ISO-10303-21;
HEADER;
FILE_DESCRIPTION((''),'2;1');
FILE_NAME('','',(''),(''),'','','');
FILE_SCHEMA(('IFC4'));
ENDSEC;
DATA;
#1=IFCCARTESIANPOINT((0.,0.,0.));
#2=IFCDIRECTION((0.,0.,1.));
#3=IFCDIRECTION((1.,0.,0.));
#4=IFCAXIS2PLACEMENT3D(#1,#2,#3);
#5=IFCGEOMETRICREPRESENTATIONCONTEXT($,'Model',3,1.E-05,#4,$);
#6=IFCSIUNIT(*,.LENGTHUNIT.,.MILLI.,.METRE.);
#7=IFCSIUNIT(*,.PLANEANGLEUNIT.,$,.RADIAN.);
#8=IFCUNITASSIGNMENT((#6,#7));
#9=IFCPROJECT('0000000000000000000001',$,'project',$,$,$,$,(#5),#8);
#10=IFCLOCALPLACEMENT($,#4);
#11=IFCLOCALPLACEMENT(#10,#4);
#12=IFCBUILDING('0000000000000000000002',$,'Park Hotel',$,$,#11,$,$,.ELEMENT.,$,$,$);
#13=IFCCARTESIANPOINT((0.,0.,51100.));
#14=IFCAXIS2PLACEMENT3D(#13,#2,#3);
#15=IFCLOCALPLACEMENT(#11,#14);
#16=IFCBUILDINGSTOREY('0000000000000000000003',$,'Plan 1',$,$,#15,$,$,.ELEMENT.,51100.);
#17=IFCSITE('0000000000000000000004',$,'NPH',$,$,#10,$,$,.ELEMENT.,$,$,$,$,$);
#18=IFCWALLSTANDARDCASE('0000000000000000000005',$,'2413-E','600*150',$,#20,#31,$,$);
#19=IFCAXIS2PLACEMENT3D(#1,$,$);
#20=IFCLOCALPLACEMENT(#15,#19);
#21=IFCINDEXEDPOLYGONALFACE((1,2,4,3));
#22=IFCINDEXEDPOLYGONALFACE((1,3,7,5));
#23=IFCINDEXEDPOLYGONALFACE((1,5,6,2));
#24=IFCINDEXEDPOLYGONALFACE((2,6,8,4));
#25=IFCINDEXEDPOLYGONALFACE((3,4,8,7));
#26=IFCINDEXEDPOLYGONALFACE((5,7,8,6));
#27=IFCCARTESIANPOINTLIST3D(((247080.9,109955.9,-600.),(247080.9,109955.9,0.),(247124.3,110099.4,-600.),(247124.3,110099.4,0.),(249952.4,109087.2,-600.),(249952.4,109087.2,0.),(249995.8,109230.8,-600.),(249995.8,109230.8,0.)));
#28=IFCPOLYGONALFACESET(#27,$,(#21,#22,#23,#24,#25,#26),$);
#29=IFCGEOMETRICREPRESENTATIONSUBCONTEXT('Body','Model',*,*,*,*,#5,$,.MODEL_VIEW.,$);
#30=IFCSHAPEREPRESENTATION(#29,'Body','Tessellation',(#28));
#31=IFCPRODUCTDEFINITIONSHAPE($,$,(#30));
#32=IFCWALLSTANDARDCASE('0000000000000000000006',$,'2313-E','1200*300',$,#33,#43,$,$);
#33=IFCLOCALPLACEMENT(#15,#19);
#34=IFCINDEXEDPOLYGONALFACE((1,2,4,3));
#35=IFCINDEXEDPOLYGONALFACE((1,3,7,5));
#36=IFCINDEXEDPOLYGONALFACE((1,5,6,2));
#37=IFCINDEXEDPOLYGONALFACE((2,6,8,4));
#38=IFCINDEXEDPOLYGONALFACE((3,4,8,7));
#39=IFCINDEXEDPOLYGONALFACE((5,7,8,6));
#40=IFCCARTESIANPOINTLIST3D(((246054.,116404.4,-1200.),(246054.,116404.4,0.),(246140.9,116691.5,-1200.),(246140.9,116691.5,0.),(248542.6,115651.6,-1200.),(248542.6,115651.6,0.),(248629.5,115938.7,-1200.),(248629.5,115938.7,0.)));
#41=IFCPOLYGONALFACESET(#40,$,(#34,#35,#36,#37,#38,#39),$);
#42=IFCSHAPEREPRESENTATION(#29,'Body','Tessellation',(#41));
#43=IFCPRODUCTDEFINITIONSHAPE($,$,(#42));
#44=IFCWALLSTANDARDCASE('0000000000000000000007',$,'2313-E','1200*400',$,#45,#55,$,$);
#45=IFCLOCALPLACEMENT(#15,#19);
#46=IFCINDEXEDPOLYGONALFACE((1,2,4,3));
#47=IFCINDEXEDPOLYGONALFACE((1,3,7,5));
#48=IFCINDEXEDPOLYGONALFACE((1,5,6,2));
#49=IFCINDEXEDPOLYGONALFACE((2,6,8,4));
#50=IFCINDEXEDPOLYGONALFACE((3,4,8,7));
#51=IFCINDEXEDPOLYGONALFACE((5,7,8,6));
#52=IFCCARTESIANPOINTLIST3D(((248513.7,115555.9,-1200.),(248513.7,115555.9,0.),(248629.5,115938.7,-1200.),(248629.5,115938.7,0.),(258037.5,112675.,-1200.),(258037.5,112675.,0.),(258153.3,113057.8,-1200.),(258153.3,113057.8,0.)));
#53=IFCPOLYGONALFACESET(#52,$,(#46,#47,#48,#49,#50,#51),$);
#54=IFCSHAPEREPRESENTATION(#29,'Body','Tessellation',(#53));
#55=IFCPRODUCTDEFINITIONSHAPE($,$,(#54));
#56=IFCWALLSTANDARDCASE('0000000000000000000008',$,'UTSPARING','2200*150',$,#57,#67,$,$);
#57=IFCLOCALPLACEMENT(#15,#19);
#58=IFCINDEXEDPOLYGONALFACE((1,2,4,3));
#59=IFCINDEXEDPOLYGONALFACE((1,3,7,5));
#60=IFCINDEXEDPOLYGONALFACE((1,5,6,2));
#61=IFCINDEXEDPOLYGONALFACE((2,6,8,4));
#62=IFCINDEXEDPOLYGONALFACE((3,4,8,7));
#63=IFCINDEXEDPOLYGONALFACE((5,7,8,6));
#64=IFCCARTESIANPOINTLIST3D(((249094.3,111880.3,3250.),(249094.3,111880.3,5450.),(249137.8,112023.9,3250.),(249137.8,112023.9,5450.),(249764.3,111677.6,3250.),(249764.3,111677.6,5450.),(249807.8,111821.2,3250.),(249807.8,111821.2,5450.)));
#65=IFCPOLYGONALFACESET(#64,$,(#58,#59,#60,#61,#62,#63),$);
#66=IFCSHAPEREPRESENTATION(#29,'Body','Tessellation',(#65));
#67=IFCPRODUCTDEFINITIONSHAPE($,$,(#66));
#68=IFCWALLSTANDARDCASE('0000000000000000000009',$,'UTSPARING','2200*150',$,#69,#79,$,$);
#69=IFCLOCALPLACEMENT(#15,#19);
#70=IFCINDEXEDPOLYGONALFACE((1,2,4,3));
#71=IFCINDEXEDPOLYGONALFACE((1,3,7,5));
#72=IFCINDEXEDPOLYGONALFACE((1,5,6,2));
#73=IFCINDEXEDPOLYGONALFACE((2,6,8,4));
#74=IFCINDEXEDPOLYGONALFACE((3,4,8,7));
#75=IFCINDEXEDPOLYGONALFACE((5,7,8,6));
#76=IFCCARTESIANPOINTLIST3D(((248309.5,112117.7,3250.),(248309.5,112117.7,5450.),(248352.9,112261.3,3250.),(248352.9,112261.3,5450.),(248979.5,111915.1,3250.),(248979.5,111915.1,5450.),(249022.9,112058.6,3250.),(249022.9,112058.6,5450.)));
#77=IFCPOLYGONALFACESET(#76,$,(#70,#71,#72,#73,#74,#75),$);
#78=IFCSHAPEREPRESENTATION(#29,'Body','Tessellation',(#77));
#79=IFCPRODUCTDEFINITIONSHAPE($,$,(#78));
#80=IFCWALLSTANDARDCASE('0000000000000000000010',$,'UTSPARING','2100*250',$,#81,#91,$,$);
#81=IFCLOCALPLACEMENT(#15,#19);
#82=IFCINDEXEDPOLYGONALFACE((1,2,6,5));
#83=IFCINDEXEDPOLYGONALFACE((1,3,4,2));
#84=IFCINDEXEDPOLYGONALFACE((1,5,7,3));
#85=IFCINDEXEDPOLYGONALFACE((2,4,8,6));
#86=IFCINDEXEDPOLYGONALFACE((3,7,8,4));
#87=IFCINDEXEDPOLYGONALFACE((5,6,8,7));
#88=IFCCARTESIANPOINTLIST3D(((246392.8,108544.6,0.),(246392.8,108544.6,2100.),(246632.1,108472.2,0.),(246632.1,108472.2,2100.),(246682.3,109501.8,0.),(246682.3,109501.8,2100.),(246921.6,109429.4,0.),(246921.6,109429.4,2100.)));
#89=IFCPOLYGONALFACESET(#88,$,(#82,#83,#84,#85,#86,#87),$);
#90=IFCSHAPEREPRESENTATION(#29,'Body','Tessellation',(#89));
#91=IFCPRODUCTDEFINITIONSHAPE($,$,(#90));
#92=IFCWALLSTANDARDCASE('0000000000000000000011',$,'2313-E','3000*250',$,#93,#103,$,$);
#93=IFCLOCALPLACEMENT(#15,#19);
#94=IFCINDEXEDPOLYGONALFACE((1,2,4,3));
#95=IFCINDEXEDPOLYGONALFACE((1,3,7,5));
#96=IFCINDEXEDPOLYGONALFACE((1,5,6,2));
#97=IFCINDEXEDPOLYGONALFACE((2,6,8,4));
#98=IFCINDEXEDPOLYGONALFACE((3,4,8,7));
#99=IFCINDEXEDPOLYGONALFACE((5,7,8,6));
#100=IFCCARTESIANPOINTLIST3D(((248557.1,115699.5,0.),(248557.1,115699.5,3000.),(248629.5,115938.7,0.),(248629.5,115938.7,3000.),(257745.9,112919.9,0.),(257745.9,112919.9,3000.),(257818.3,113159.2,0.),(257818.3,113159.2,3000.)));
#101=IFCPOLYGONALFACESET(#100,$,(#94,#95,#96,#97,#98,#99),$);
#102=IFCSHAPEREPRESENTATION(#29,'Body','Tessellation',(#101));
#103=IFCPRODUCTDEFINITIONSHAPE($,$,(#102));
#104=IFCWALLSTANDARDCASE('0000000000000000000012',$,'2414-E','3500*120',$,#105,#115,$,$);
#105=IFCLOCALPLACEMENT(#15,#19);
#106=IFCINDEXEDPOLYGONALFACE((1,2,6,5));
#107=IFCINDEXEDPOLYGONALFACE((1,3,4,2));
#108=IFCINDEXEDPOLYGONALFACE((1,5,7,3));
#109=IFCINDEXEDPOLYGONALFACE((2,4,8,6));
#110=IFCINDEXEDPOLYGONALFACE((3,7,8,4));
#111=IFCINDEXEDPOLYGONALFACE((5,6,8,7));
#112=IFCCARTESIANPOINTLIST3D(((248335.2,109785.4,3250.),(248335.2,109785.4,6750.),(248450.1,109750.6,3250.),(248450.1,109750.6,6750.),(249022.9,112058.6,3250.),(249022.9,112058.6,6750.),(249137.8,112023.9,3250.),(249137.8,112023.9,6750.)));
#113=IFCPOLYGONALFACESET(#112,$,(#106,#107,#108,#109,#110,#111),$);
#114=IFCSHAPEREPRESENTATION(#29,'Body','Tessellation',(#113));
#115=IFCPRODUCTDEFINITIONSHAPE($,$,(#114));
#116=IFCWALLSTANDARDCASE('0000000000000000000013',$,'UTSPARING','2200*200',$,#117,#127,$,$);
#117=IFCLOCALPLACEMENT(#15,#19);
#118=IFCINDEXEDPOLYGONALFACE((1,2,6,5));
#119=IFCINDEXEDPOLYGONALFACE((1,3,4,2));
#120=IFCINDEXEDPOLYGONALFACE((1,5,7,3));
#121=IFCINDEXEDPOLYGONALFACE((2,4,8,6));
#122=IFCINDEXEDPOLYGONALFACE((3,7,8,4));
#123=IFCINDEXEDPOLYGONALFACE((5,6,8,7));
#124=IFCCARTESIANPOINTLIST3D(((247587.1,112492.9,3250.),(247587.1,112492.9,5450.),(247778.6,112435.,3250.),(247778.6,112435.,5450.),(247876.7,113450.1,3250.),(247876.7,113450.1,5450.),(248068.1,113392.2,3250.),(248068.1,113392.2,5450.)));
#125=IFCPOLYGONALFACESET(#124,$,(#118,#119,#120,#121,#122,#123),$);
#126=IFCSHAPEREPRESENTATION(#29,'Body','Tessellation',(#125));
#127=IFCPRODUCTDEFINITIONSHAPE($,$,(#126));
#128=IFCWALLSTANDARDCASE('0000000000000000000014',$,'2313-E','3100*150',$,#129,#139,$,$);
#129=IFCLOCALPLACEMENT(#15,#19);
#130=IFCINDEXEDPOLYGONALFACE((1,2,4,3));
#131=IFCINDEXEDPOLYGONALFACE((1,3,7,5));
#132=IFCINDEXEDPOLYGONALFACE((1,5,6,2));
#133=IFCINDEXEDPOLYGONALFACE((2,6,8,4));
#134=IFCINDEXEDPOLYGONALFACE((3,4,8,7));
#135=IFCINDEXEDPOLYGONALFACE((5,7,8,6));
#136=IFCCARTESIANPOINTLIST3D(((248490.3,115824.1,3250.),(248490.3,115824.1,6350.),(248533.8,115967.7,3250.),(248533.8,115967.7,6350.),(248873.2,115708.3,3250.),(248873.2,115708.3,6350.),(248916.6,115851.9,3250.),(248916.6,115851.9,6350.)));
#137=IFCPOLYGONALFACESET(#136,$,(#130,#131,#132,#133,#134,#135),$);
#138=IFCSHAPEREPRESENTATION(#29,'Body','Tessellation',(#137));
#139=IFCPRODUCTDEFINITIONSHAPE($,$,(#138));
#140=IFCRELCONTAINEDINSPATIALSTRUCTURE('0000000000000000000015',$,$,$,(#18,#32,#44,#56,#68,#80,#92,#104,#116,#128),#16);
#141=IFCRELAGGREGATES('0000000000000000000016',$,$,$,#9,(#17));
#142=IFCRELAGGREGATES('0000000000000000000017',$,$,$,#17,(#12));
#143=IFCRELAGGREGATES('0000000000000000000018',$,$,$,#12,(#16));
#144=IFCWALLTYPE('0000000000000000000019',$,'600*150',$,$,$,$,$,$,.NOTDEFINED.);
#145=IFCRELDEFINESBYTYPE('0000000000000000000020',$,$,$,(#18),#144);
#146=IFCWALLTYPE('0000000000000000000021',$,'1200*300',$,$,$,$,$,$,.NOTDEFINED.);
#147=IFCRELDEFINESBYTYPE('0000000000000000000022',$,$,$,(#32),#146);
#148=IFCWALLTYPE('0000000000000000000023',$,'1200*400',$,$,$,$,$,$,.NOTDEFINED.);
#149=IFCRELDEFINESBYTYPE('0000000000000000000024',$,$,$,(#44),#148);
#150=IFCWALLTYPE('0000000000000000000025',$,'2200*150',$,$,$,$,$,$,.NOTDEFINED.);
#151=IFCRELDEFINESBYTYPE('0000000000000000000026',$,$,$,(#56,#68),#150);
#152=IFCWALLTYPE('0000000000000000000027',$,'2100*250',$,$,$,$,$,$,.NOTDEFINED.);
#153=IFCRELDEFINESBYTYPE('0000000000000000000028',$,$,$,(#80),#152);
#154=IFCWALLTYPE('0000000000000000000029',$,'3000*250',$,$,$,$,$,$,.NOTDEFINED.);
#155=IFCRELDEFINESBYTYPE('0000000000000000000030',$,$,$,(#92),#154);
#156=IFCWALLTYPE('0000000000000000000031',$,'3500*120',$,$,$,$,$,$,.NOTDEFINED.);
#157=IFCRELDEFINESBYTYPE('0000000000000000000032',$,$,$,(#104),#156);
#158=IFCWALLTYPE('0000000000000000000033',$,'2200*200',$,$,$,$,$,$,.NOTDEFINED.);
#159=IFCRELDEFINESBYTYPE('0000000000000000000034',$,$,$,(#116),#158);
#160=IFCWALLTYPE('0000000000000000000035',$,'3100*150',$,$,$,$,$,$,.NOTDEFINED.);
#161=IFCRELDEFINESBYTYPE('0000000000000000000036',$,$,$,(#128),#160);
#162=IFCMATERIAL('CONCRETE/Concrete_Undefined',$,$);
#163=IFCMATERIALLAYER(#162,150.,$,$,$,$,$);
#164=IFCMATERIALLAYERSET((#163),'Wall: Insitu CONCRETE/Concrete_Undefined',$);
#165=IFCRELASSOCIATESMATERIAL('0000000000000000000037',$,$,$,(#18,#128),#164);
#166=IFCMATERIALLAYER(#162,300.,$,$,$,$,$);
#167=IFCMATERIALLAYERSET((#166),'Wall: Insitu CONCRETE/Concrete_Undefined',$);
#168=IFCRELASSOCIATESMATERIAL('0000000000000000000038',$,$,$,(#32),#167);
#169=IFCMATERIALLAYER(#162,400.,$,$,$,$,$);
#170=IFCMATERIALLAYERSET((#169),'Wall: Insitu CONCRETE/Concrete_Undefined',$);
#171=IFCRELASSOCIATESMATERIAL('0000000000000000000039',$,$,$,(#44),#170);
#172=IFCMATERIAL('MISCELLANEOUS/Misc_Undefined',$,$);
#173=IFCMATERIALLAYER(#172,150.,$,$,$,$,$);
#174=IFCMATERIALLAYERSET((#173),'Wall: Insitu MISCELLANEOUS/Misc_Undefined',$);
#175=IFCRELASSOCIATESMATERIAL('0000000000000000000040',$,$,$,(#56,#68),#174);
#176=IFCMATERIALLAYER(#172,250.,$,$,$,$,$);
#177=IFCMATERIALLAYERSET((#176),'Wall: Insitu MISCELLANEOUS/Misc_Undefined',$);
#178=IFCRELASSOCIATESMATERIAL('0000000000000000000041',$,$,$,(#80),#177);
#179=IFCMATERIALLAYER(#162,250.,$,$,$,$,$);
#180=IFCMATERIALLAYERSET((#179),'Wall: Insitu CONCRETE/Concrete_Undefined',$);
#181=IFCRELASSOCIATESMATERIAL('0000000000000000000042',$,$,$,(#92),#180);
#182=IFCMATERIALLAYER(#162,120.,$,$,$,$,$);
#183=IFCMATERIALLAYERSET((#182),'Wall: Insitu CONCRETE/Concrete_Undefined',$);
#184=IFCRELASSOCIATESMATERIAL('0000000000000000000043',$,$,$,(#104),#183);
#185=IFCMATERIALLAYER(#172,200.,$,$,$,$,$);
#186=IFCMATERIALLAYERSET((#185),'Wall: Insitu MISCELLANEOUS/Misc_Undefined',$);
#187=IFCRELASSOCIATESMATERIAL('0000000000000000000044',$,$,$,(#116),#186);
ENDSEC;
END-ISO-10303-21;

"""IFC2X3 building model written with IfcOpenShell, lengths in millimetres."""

from ifc_helpers import new_model, si_unit, frame, frame_2d, origin_with_axes, place, context, subcontext, project, spatial, rectangle, extrude, material, layer, layer_set, layer_usage, type_object, element, save


model = new_model("IFC2X3")

# Units and contexts
model_context = context("Model", 3, precision=1e-05, world=origin_with_axes())
body_context = subcontext(model_context, "Body", "Model", "MODEL_VIEW")
ifc_project = project(units=[si_unit("LENGTHUNIT", "METRE", prefix="MILLI"), si_unit("PLANEANGLEUNIT", "RADIAN")], contexts=[model_context])

# Site, building, storey
site_placement = place(None, origin_with_axes())
site = spatial("IfcSite", under=ifc_project, at=site_placement, Name="NPH", CompositionType="ELEMENT")
building_placement = place(site_placement, origin_with_axes())
building = spatial("IfcBuilding", under=site, at=building_placement, Name="Park Hotel", CompositionType="ELEMENT")
storey_placement = place(building_placement, frame((0.0, 0.0, 51100.0), z_axis=(0.0, 0.0, 1.0), x_axis=(1.0, 0.0, 0.0)))
storey = spatial("IfcBuildingStorey", under=building, at=storey_placement, Name="Plan 1", CompositionType="ELEMENT", Elevation=51100.0)

# Shared definitions
ifc_material_1 = material(Name="CONCRETE/Concrete_Undefined")

# Shared definitions
ifc_material_2 = material(Name="MISCELLANEOUS/Misc_Undefined")

# Walls
ifc_layer_1 = layer(ifc_material_1, 150.0)
ifc_layer_set_1 = layer_set([ifc_layer_1], Name="Wall: Insitu CONCRETE/Concrete_Undefined")
ifc_layer_usage_1 = layer_usage(ifc_layer_set_1, "AXIS2", "POSITIVE", -75.0)
wall_type_1 = type_object("IfcWallType", Name="600*150", PredefinedType="NOTDEFINED")
wall_1_placement = place(storey_placement, frame((247102.6, 110027.6, -600.0), z_axis=(0.0, 0.0, 1.0), x_axis=(0.957167, -0.289536, 0.0)))
element("IfcWallStandardCase", 1, at=wall_1_placement, inside=storey, type_object=wall_type_1, material=ifc_layer_usage_1, Name="2413-E", Description="600*150", context=body_context, shape_type="SweptSolid", body=[
    extrude(rectangle(XDim=3000.0, YDim=150.0, at=frame_2d((0.0, 1500.0), x_axis=(0.0, -1.0))), frame((0.0, 0.0, 0.0), z_axis=(0.0, 0.0, 1.0), x_axis=(0.0, -1.0, 0.0)), (0.0, 0.0, 1.0), 600.0),
])
ifc_layer_2 = layer(ifc_material_1, 300.0)
ifc_layer_set_2 = layer_set([ifc_layer_2], Name="Wall: Insitu CONCRETE/Concrete_Undefined")
ifc_layer_usage_2 = layer_usage(ifc_layer_set_2, "AXIS2", "POSITIVE", -150.0)
wall_type_2 = type_object("IfcWallType", Name="1200*300", PredefinedType="NOTDEFINED")
wall_2_placement = place(storey_placement, frame((246097.4, 116548.0, -1200.0), z_axis=(0.0, 0.0, 1.0), x_axis=(0.957166, -0.289541, 0.0)))
element("IfcWallStandardCase", 2, at=wall_2_placement, inside=storey, type_object=wall_type_2, material=ifc_layer_usage_2, Name="2313-E", Description="1200*300", context=body_context, shape_type="SweptSolid", body=[
    extrude(rectangle(XDim=2600.0, YDim=300.0, at=frame_2d((0.0, 1300.0), x_axis=(0.0, -1.0))), frame((0.0, 0.0, 0.0), z_axis=(0.0, 0.0, 1.0), x_axis=(0.0, -1.0, 0.0)), (0.0, 0.0, 1.0), 1200.0),
])
ifc_layer_3 = layer(ifc_material_1, 400.0)
ifc_layer_set_3 = layer_set([ifc_layer_3], Name="Wall: Insitu CONCRETE/Concrete_Undefined")
ifc_layer_usage_3 = layer_usage(ifc_layer_set_3, "AXIS2", "POSITIVE", -200.0)
wall_type_3 = type_object("IfcWallType", Name="1200*400", PredefinedType="NOTDEFINED")
wall_3_placement = place(storey_placement, frame((248571.6, 115747.3, -1200.0), z_axis=(0.0, 0.0, 1.0), x_axis=(0.957167, -0.289538, 0.0)))
element("IfcWallStandardCase", 3, at=wall_3_placement, inside=storey, type_object=wall_type_3, material=ifc_layer_usage_3, Name="2313-E", Description="1200*400", context=body_context, shape_type="SweptSolid", body=[
    extrude(rectangle(XDim=9950.0, YDim=400.0, at=frame_2d((0.0, 4975.0), x_axis=(0.0, -1.0))), frame((0.0, 0.0, 0.0), z_axis=(0.0, 0.0, 1.0), x_axis=(0.0, -1.0, 0.0)), (0.0, 0.0, 1.0), 1200.0),
])
ifc_layer_4 = layer(ifc_material_2, 150.0)
ifc_layer_set_4 = layer_set([ifc_layer_4], Name="Wall: Insitu MISCELLANEOUS/Misc_Undefined")
ifc_layer_usage_4 = layer_usage(ifc_layer_set_4, "AXIS2", "POSITIVE", -75.0)
wall_type_4 = type_object("IfcWallType", Name="2200*150", PredefinedType="NOTDEFINED")
wall_4_placement = place(storey_placement, frame((249786.1, 111749.4, 3250.0), z_axis=(0.0, 0.0, 1.0), x_axis=(-0.957165, 0.289542, 0.0)))
element("IfcWallStandardCase", 4, at=wall_4_placement, inside=storey, type_object=wall_type_4, material=ifc_layer_usage_4, Name="UTSPARING", Description="2200*150", context=body_context, shape_type="SweptSolid", body=[
    extrude(rectangle(XDim=700.0, YDim=150.0, at=frame_2d((0.0, 350.0), x_axis=(0.0, -1.0))), frame((0.0, 0.0, 0.0), z_axis=(0.0, 0.0, 1.0), x_axis=(0.0, -1.0, 0.0)), (0.0, 0.0, 1.0), 2200.0),
])
ifc_layer_usage_5 = layer_usage(ifc_layer_set_4, "AXIS2", "POSITIVE", -75.0)
wall_5_placement = place(storey_placement, frame((249001.2, 111986.8, 3250.0), z_axis=(0.0, 0.0, 1.0), x_axis=(-0.957165, 0.289542, 0.0)))
element("IfcWallStandardCase", 5, at=wall_5_placement, inside=storey, type_object=wall_type_4, material=ifc_layer_usage_5, Name="UTSPARING", Description="2200*150", context=body_context, shape_type="SweptSolid", body=[
    extrude(rectangle(XDim=700.0, YDim=150.0, at=frame_2d((0.0, 350.0), x_axis=(0.0, -1.0))), frame((0.0, 0.0, 0.0), z_axis=(0.0, 0.0, 1.0), x_axis=(0.0, -1.0, 0.0)), (0.0, 0.0, 1.0), 2200.0),
])
ifc_layer_5 = layer(ifc_material_2, 250.0)
ifc_layer_set_5 = layer_set([ifc_layer_5], Name="Wall: Insitu MISCELLANEOUS/Misc_Undefined")
ifc_layer_usage_6 = layer_usage(ifc_layer_set_5, "AXIS2", "POSITIVE", -125.0)
wall_type_5 = type_object("IfcWallType", Name="2100*250", PredefinedType="NOTDEFINED")
wall_6_placement = place(storey_placement, frame((246802.0, 109465.6, 0.0), z_axis=(0.0, 0.0, 1.0), x_axis=(-0.289542, -0.957165, 0.0)))
element("IfcWallStandardCase", 6, at=wall_6_placement, inside=storey, type_object=wall_type_5, material=ifc_layer_usage_6, Name="UTSPARING", Description="2100*250", context=body_context, shape_type="SweptSolid", body=[
    extrude(rectangle(XDim=1000.0, YDim=250.0, at=frame_2d((0.0, 500.0), x_axis=(0.0, -1.0))), frame((0.0, 0.0, 0.0), z_axis=(0.0, 0.0, 1.0), x_axis=(0.0, -1.0, 0.0)), (0.0, 0.0, 1.0), 2100.0),
])
ifc_layer_6 = layer(ifc_material_1, 250.0)
ifc_layer_set_6 = layer_set([ifc_layer_6], Name="Wall: Insitu CONCRETE/Concrete_Undefined")
ifc_layer_usage_7 = layer_usage(ifc_layer_set_6, "AXIS2", "POSITIVE", -125.0)
wall_type_6 = type_object("IfcWallType", Name="3000*250", PredefinedType="NOTDEFINED")
wall_7_placement = place(storey_placement, frame((248593.3, 115819.1, 0.0), z_axis=(0.0, 0.0, 1.0), x_axis=(0.957167, -0.289538, 0.0)))
element("IfcWallStandardCase", 7, at=wall_7_placement, inside=storey, type_object=wall_type_6, material=ifc_layer_usage_7, Name="2313-E", Description="3000*250", context=body_context, shape_type="SweptSolid", body=[
    extrude(rectangle(XDim=9600.0, YDim=250.0, at=frame_2d((0.0, 4800.0), x_axis=(0.0, -1.0))), frame((0.0, 0.0, 0.0), z_axis=(0.0, 0.0, 1.0), x_axis=(0.0, -1.0, 0.0)), (0.0, 0.0, 1.0), 3000.0),
])
ifc_layer_7 = layer(ifc_material_1, 120.0)
ifc_layer_set_7 = layer_set([ifc_layer_7], Name="Wall: Insitu CONCRETE/Concrete_Undefined")
ifc_layer_usage_8 = layer_usage(ifc_layer_set_7, "AXIS2", "POSITIVE", -60.0)
wall_type_7 = type_object("IfcWallType", Name="3500*120", PredefinedType="NOTDEFINED")
wall_8_placement = place(storey_placement, frame((249080.3, 112041.3, 3250.0), z_axis=(0.0, 0.0, 1.0), x_axis=(-0.289542, -0.957165, 0.0)))
element("IfcWallStandardCase", 8, at=wall_8_placement, inside=storey, type_object=wall_type_7, material=ifc_layer_usage_8, Name="2414-E", Description="3500*120", context=body_context, shape_type="SweptSolid", body=[
    extrude(rectangle(XDim=2375.0, YDim=120.0, at=frame_2d((0.0, 1187.5), x_axis=(0.0, -1.0))), frame((0.0, 0.0, 0.0), z_axis=(0.0, 0.0, 1.0), x_axis=(0.0, -1.0, 0.0)), (0.0, 0.0, 1.0), 3500.0),
])
ifc_layer_8 = layer(ifc_material_2, 200.0)
ifc_layer_set_8 = layer_set([ifc_layer_8], Name="Wall: Insitu MISCELLANEOUS/Misc_Undefined")
ifc_layer_usage_9 = layer_usage(ifc_layer_set_8, "AXIS2", "POSITIVE", -100.0)
wall_type_8 = type_object("IfcWallType", Name="2200*200", PredefinedType="NOTDEFINED")
wall_9_placement = place(storey_placement, frame((247972.4, 113421.2, 3250.0), z_axis=(0.0, 0.0, 1.0), x_axis=(-0.289542, -0.957165, 0.0)))
element("IfcWallStandardCase", 9, at=wall_9_placement, inside=storey, type_object=wall_type_8, material=ifc_layer_usage_9, Name="UTSPARING", Description="2200*200", context=body_context, shape_type="SweptSolid", body=[
    extrude(rectangle(XDim=1000.0, YDim=200.0, at=frame_2d((0.0, 500.0), x_axis=(0.0, -1.0))), frame((0.0, 0.0, 0.0), z_axis=(0.0, 0.0, 1.0), x_axis=(0.0, -1.0, 0.0)), (0.0, 0.0, 1.0), 2200.0),
])
ifc_layer_usage_10 = layer_usage(ifc_layer_set_1, "AXIS2", "POSITIVE", -75.0)
wall_type_9 = type_object("IfcWallType", Name="3100*150", PredefinedType="NOTDEFINED")
wall_10_placement = place(storey_placement, frame((248512.1, 115895.9, 3250.0), z_axis=(0.0, 0.0, 1.0), x_axis=(0.957161, -0.289556, 0.0)))
element("IfcWallStandardCase", 10, at=wall_10_placement, inside=storey, type_object=wall_type_9, material=ifc_layer_usage_10, Name="2313-E", Description="3100*150", context=body_context, shape_type="SweptSolid", body=[
    extrude(rectangle(XDim=400.0, YDim=150.0, at=frame_2d((0.0, 200.0), x_axis=(0.0, -1.0))), frame((0.0, 0.0, 0.0), z_axis=(0.0, 0.0, 1.0), x_axis=(0.0, -1.0, 0.0)), (0.0, 0.0, 1.0), 3100.0),
])

save(model, "model.ifc")
